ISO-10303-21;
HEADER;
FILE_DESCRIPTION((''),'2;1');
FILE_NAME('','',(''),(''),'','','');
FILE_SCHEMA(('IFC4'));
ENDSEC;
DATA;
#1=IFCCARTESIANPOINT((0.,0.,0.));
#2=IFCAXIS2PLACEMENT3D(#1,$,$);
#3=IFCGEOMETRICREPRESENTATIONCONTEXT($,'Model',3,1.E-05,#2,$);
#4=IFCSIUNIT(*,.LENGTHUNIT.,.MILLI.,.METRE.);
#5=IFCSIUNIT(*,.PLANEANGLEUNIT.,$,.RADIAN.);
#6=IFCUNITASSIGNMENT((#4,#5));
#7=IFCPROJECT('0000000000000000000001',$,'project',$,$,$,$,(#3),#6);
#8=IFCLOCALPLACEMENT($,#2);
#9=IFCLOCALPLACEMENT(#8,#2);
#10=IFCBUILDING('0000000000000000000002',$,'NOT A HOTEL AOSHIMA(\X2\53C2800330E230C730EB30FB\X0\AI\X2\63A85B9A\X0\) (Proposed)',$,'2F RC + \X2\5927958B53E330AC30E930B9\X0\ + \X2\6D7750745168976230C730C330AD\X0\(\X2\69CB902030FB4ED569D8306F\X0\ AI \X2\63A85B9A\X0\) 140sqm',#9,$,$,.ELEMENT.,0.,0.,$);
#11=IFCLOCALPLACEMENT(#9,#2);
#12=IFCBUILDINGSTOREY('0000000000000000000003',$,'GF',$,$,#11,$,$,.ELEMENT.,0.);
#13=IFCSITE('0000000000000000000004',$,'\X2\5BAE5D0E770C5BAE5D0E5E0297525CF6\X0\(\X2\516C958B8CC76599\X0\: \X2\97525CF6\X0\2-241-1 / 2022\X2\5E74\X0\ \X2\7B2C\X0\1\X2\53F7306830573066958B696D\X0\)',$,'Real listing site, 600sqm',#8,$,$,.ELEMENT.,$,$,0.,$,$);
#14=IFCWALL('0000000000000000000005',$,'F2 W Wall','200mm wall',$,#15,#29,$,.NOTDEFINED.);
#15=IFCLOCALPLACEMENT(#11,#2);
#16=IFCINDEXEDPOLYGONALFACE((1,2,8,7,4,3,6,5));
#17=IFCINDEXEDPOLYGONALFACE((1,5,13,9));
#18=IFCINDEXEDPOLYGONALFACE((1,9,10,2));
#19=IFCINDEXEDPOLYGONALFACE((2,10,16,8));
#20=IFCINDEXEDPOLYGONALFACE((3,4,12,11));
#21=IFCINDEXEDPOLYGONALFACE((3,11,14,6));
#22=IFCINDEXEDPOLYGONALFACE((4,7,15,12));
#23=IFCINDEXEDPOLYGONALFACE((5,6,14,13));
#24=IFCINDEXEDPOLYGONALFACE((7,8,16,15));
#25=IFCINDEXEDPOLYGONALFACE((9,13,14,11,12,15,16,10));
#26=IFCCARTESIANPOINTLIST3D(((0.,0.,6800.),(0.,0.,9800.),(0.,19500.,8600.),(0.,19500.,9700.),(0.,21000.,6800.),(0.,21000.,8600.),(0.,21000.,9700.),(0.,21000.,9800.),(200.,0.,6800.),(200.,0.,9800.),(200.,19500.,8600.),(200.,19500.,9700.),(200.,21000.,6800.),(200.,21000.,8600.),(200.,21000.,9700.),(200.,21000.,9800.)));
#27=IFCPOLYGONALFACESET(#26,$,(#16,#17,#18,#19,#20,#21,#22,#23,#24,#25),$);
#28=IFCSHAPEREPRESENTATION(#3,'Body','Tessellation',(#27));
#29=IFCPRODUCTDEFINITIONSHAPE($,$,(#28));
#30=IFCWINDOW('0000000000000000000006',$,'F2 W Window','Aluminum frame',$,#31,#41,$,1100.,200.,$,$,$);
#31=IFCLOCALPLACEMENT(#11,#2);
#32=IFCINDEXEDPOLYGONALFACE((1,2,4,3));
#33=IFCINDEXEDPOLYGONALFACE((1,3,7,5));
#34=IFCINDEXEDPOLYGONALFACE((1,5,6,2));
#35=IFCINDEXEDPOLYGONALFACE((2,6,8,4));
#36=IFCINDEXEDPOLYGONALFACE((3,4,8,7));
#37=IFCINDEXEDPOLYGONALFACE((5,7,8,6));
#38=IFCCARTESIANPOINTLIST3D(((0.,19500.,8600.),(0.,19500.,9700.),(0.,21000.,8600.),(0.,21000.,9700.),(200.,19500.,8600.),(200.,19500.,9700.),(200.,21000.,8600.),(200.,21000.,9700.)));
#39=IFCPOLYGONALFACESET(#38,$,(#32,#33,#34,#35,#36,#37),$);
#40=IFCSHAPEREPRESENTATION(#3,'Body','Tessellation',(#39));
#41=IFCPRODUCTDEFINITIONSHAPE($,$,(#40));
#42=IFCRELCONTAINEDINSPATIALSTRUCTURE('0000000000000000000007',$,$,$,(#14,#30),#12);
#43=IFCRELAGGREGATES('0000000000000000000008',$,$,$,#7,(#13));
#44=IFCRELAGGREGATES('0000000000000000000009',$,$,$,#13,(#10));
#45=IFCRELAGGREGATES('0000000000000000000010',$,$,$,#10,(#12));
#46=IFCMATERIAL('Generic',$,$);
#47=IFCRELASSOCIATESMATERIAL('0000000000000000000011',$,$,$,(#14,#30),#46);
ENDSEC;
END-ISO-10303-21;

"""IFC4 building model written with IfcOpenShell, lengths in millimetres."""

from ifc_helpers import new_model, si_unit, frame, frame_2d, origin, place, context, project, spatial, rectangle, extrude, material, element, fill, save


model = new_model("IFC4")

# Units and contexts
model_context = context("Model", 3, precision=1e-05, world=origin())
ifc_project = project(units=[si_unit("LENGTHUNIT", "METRE", prefix="MILLI"), si_unit("PLANEANGLEUNIT", "RADIAN")], contexts=[model_context])

# Site, building, storey
site_placement = place(None, origin())
site = spatial("IfcSite", under=ifc_project, at=site_placement, Name="宮崎県宮崎市青島(公開資料: 青島2-241-1 / 2022年 第1号として開業)", ObjectType="Real listing site, 600sqm", CompositionType="ELEMENT", RefElevation=0.0)
building_placement = place(site_placement, origin())
building = spatial("IfcBuilding", under=site, at=building_placement, Name="NOT A HOTEL AOSHIMA(参考モデル・AI推定) (Proposed)", ObjectType="2F RC + 大開口ガラス + 海側全面デッキ(構造・仕様は AI 推定) 140sqm", CompositionType="ELEMENT", ElevationOfRefHeight=0.0, ElevationOfTerrain=0.0)
storey_placement = place(building_placement, origin())
storey = spatial("IfcBuildingStorey", under=building, at=storey_placement, Name="GF", CompositionType="ELEMENT", Elevation=0.0)

# Shared definitions
ifc_material_1 = material(Name="Generic")

# Wall, opening, window
wall_1_placement = place(storey_placement, frame((0.0, 0.0, 3400.0)))
wall_1 = element("IfcWall", 1, at=wall_1_placement, inside=storey, material=ifc_material_1, Name="F2 W Wall", Description="200mm wall", PredefinedType="NOTDEFINED", context=model_context, shape_type="SweptSolid", body=[
    extrude(rectangle(XDim=200.0, YDim=21000.0, at=frame_2d((100.0, 10500.0))), frame((0.0, 0.0, 3400.0)), (0.0, 0.0, 1.0), 3000.0),
])
opening_1_placement = place(storey_placement, frame((0.0, 9750.0, 4300.0)))
opening_1 = element("IfcOpeningElement", 2, at=opening_1_placement, cuts=wall_1, PredefinedType="NOTDEFINED", context=model_context, shape_type="SweptSolid", body=[
    extrude(rectangle(XDim=200.0, YDim=1500.0, at=frame_2d((100.0, 750.0))), frame((0.0, 9750.0, 4300.0)), (0.0, 0.0, 1.0), 1100.0),
])
window_1_placement = place(storey_placement, frame((0.0, 9750.0, 4300.0)))
window_1 = element("IfcWindow", 3, at=window_1_placement, inside=storey, material=ifc_material_1, Name="F2 W Window", Description="Aluminum frame", OverallHeight=1100.0, OverallWidth=200.0, context=model_context, shape_type="SweptSolid", body=[
    extrude(rectangle(XDim=200.0, YDim=1500.0, at=frame_2d((100.0, 750.0))), frame((0.0, 9750.0, 4300.0)), (0.0, 0.0, 1.0), 1100.0),
])
fill(opening_1, window_1)

save(model, "model.ifc")
